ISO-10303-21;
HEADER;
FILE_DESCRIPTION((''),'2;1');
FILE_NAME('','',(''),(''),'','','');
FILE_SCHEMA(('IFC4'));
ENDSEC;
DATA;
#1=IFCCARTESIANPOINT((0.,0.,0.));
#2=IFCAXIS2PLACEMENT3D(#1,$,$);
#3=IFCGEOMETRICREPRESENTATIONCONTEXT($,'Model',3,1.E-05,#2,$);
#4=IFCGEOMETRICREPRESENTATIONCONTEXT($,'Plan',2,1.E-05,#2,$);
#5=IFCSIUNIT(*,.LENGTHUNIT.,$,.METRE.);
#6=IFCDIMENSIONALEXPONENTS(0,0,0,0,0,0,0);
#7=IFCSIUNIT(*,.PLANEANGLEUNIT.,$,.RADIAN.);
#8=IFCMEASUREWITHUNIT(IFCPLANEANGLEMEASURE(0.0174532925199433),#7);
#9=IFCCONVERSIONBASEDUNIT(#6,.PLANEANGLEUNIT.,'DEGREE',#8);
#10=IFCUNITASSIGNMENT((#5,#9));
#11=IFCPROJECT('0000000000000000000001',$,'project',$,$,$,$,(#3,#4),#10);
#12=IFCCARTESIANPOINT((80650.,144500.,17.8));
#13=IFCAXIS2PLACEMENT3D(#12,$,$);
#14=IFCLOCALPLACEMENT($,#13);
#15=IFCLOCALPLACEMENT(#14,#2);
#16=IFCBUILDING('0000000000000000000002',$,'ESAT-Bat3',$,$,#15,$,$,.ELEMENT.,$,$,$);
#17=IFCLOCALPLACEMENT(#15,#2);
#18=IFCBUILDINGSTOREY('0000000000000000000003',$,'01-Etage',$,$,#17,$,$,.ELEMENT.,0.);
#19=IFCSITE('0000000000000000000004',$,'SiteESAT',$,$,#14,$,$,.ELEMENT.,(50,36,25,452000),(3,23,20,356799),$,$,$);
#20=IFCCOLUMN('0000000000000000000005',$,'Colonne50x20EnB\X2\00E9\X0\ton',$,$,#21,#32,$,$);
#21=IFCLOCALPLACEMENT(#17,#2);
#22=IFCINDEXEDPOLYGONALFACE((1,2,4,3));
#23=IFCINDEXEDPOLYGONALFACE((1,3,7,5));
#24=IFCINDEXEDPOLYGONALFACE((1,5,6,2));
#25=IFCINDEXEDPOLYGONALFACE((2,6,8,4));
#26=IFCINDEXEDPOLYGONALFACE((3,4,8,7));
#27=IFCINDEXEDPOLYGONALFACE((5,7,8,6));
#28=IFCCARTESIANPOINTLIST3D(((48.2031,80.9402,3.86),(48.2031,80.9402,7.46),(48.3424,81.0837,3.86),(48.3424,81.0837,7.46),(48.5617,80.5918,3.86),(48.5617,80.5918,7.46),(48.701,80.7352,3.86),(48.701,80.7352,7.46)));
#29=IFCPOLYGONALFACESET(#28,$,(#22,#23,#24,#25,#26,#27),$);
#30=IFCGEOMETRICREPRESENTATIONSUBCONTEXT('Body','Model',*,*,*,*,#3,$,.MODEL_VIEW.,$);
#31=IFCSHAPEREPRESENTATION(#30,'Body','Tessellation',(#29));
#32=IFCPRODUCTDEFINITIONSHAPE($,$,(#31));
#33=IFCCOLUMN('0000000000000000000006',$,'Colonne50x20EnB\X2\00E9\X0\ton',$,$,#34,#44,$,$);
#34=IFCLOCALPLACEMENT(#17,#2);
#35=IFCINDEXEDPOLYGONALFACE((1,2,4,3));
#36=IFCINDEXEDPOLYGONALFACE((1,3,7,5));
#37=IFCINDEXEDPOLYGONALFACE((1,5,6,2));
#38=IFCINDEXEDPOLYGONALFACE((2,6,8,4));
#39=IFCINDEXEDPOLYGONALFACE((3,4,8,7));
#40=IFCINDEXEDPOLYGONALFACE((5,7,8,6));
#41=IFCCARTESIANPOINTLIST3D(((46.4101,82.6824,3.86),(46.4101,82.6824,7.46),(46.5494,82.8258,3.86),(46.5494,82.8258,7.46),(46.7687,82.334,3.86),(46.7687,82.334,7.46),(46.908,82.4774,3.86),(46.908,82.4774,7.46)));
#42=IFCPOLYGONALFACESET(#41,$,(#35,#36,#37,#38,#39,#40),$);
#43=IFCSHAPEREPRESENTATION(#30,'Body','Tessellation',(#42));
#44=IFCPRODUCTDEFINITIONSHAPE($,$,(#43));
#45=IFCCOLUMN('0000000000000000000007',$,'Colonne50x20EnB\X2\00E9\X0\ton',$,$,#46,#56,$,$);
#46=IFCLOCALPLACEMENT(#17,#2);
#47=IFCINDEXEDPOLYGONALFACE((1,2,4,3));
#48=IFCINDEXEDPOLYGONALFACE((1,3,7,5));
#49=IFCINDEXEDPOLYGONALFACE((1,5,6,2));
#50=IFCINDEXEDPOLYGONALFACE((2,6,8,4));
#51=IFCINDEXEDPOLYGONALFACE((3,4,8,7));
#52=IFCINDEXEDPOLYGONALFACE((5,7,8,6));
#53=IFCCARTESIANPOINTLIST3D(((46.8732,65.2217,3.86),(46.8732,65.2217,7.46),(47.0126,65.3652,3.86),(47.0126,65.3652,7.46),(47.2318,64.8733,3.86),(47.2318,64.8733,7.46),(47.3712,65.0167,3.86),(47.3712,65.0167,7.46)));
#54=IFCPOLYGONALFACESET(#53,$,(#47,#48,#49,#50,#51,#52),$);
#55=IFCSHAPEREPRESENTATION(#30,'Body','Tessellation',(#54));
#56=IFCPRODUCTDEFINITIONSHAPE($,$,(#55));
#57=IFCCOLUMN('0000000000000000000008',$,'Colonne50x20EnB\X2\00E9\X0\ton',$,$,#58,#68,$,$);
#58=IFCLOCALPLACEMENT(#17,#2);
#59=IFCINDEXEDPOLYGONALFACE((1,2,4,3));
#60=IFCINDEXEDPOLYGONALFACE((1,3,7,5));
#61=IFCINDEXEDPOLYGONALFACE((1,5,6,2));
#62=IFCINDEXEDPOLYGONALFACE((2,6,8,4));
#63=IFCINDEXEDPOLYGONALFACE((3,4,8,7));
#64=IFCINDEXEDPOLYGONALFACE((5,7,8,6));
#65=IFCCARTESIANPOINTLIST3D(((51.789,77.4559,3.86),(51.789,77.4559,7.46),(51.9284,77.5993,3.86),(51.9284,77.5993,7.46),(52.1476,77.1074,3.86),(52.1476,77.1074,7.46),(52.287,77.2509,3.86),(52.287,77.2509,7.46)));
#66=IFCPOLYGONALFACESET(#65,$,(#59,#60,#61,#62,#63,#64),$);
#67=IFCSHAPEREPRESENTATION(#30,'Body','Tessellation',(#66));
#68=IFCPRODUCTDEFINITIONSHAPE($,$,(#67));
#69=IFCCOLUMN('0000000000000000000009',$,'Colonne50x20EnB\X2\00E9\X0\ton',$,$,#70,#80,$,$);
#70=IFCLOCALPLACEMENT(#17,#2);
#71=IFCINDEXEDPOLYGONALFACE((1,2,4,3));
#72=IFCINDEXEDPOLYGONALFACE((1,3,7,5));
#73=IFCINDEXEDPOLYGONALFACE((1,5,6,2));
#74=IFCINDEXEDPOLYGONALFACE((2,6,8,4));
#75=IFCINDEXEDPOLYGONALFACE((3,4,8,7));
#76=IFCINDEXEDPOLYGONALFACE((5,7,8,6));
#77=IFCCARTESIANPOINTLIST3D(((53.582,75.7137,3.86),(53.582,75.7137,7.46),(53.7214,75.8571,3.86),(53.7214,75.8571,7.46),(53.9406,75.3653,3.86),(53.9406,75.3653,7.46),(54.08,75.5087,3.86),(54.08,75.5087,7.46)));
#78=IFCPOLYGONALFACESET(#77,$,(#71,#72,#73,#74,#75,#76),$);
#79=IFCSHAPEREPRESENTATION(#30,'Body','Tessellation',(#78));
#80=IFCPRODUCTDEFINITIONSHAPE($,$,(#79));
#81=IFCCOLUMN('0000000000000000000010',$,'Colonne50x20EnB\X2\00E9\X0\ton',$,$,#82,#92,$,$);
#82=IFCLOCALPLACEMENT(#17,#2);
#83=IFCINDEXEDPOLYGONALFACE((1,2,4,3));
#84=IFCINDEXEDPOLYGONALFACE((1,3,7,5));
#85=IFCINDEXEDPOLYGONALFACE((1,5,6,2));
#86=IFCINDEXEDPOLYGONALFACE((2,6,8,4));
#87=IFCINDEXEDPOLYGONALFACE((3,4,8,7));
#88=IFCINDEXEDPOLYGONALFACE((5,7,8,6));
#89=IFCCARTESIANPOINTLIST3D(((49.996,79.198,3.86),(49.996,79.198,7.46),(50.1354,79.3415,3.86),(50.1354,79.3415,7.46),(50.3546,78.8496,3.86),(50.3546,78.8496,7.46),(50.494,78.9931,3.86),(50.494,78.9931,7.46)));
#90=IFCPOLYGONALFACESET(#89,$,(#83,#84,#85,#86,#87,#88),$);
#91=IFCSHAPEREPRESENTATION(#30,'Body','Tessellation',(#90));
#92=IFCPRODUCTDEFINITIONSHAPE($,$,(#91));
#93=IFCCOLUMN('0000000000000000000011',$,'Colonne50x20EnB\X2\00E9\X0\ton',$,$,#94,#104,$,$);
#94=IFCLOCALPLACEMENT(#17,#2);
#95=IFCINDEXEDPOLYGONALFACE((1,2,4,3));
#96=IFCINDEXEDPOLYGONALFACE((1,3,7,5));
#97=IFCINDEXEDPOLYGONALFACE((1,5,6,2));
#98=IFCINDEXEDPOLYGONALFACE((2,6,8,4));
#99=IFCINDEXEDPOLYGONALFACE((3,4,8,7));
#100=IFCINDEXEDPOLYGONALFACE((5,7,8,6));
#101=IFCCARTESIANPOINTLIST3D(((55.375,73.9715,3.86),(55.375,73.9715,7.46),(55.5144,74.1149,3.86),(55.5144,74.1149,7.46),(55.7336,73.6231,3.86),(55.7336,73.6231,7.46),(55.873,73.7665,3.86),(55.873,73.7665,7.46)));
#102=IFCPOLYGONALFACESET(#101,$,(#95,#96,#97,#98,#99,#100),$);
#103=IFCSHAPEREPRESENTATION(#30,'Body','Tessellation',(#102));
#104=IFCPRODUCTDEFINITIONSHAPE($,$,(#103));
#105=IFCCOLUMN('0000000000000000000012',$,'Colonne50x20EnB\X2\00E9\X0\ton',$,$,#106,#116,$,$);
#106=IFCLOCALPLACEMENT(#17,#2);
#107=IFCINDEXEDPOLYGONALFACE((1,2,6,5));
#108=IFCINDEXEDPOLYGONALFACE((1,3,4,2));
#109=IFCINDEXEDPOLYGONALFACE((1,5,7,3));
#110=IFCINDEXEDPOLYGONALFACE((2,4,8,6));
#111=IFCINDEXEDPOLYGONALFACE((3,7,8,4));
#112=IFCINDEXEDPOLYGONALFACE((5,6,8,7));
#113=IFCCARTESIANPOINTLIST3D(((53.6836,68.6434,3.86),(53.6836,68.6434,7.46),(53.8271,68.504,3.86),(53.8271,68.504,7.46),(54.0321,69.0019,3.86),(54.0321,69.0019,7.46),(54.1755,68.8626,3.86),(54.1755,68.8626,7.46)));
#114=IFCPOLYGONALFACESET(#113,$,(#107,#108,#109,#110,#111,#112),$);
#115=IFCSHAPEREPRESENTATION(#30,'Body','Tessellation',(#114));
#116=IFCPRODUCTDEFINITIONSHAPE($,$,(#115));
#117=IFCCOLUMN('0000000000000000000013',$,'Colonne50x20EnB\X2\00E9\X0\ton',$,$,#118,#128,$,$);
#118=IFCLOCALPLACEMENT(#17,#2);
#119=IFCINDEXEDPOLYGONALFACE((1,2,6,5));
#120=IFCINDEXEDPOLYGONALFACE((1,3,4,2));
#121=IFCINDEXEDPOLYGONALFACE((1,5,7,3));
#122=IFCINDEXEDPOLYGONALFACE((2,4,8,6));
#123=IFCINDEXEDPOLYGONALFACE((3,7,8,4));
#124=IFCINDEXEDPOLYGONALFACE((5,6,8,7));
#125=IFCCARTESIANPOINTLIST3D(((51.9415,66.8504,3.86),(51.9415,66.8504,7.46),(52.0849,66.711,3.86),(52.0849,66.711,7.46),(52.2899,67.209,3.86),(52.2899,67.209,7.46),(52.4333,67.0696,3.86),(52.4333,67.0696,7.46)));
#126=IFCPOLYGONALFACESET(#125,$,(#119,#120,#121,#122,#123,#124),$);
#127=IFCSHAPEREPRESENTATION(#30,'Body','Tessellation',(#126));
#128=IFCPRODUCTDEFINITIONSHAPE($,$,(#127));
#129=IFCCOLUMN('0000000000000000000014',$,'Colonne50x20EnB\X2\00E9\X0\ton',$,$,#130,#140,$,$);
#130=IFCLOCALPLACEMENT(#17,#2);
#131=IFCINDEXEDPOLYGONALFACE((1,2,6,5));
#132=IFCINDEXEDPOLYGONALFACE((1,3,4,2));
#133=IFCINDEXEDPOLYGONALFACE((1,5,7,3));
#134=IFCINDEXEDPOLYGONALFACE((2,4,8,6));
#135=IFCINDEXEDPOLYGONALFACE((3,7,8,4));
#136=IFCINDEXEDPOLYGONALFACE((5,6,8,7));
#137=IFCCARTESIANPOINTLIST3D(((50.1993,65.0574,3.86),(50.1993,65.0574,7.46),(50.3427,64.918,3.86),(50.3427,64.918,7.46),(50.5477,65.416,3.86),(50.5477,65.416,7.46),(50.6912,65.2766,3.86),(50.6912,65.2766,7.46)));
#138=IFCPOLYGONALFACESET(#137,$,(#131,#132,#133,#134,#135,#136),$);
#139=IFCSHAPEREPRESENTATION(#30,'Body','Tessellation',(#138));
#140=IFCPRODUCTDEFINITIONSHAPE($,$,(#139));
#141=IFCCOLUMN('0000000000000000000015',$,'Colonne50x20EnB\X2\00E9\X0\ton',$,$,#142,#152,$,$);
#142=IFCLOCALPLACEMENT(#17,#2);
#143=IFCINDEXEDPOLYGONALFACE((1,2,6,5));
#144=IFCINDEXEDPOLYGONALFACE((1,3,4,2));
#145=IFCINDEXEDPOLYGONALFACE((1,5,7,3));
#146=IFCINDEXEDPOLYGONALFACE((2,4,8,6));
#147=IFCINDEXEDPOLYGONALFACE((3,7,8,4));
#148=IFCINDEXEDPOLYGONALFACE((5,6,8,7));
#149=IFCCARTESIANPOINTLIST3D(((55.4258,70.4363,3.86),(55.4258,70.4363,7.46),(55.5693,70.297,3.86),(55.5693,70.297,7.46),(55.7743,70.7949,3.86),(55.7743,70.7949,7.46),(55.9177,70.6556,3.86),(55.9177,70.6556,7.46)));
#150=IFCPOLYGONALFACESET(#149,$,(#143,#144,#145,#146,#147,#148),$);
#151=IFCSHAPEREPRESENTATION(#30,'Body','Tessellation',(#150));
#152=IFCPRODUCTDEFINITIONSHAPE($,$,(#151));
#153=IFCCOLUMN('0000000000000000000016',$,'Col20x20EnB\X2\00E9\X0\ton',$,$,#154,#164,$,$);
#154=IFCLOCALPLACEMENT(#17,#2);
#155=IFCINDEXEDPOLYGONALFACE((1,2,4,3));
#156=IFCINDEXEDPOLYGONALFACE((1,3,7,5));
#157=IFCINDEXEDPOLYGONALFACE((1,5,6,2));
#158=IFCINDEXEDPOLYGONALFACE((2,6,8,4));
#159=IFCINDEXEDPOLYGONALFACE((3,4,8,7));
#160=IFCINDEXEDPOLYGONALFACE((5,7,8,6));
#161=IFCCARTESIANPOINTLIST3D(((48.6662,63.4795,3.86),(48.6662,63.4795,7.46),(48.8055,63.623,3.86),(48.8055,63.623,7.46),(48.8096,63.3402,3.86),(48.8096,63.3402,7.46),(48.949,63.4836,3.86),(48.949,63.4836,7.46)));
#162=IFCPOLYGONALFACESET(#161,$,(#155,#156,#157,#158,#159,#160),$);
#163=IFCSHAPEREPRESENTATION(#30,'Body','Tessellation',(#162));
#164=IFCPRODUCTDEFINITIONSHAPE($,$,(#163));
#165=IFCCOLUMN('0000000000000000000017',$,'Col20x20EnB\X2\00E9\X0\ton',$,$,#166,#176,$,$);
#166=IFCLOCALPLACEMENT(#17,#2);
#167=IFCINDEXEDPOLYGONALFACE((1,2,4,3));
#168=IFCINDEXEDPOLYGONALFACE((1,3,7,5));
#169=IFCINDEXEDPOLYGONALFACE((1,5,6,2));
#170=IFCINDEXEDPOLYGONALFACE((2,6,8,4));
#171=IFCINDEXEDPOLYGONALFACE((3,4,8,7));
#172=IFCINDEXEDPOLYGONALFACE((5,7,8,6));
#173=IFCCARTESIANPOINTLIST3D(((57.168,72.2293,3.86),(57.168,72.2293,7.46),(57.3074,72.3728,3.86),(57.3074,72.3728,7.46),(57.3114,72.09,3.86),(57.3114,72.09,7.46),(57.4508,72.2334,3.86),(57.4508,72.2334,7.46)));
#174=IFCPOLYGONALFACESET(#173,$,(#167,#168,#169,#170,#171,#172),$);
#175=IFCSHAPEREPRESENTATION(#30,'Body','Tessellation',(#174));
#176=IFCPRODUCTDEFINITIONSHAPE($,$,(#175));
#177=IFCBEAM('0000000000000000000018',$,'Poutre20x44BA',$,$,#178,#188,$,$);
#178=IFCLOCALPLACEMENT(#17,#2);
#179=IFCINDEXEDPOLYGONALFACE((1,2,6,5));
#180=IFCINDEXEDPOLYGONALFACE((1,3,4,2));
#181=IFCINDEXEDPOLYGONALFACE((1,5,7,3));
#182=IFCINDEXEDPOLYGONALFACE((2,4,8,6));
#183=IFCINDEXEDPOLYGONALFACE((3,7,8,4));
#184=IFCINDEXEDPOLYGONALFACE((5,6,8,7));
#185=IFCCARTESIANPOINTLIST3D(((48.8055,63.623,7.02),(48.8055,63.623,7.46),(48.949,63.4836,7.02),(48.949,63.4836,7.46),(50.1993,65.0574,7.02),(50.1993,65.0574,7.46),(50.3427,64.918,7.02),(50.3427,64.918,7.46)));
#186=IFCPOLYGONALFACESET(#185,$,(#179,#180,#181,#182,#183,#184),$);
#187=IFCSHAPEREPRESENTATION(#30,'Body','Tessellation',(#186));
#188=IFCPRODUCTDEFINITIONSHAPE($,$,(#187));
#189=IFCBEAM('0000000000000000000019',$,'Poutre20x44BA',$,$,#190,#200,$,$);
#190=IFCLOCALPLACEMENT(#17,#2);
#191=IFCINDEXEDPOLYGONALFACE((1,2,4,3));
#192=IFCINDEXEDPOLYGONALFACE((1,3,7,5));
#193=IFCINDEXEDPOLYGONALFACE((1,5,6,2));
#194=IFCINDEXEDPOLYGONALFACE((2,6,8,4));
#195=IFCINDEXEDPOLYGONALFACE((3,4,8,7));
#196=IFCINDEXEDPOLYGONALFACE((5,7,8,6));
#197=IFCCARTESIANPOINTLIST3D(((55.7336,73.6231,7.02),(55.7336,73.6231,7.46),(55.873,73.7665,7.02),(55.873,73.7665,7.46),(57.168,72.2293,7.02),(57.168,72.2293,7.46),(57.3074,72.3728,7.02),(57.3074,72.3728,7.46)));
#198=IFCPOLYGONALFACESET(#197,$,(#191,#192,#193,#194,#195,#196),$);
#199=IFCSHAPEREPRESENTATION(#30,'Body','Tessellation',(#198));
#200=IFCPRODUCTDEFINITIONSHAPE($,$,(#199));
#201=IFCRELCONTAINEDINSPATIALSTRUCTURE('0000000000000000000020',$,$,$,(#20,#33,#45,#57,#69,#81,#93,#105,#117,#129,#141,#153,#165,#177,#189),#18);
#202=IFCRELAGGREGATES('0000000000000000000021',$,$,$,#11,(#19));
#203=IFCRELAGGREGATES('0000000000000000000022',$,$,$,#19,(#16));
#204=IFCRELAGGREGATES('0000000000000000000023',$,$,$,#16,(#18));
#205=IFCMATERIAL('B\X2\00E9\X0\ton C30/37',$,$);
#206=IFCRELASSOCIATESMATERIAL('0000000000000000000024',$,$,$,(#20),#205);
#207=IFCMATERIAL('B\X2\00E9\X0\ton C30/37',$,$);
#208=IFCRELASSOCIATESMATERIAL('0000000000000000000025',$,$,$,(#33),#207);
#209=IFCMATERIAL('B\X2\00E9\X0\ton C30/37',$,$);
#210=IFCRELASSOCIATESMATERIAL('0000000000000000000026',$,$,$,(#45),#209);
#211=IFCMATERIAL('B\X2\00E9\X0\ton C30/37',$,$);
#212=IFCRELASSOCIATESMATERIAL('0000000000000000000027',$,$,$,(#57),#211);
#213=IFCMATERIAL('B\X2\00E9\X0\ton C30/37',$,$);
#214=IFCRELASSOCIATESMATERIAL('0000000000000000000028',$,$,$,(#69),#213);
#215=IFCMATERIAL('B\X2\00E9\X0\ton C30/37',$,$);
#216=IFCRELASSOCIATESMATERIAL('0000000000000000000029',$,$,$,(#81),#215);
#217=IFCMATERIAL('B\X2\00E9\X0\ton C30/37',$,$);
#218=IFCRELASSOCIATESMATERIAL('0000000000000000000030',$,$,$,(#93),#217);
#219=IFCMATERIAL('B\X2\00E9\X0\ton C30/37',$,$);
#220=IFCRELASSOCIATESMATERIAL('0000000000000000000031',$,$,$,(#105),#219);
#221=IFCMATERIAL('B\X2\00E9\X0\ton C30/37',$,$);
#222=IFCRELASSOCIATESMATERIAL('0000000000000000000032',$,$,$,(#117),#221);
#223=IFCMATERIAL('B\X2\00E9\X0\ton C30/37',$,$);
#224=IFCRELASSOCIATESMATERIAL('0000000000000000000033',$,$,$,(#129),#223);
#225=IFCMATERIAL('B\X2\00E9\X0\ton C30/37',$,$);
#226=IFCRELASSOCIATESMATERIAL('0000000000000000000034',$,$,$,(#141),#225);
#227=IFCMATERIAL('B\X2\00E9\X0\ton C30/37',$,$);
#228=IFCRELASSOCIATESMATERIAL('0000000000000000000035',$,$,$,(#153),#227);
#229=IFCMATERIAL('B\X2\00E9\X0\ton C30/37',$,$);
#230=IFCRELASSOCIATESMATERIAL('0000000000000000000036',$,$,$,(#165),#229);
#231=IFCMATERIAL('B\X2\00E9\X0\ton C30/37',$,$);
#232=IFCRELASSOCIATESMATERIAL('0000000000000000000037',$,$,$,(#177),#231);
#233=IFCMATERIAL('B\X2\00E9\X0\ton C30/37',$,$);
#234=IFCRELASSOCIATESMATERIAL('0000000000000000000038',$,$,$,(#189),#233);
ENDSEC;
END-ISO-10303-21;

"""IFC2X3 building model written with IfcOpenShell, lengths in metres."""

from ifc_helpers import new_model, entity, si_unit, converted_unit, frame, frame_2d, origin, origin_with_axes, place, context, subcontext, project, spatial, rectangle, extrude, material, element, save


model = new_model("IFC2X3")

# Units and contexts
model_context = context("Model", 3, precision=1e-05, world=origin())
plan_context = context("Plan", 2, precision=1e-05, world=origin())
body_context = subcontext(model_context, "Body", "Model", "MODEL_VIEW")
ifc_project = project(units=[si_unit("LENGTHUNIT", "METRE"), converted_unit("PLANEANGLEUNIT", "DEGREE", entity("IfcPlaneAngleMeasure", 0.0174532925199433), si_unit("PLANEANGLEUNIT", "RADIAN"), dimensions=[0, 0, 0, 0, 0, 0, 0])], contexts=[model_context, plan_context])

# Site, building, storey
site_placement = place(None, frame((80650.0, 144500.0, 17.8)))
site = spatial("IfcSite", under=ifc_project, at=site_placement, Name="SiteESAT", CompositionType="ELEMENT", RefLatitude=(50, 36, 25, 452000), RefLongitude=(3, 23, 20, 356799))
building_placement = place(site_placement, origin())
building = spatial("IfcBuilding", under=site, at=building_placement, Name="ESAT-Bat3", CompositionType="ELEMENT")
storey_placement = place(building_placement, origin())
storey = spatial("IfcBuildingStorey", under=building, at=storey_placement, Name="01-Etage", CompositionType="ELEMENT", Elevation=0.0)

# Columns
ifc_material_1 = material(Name="Béton C30/37")
column_1_placement = place(storey_placement, frame((48.701, 80.7352, 3.86)))
element("IfcColumn", 1, at=column_1_placement, inside=storey, material=ifc_material_1, Name="Colonne50x20EnBéton", context=body_context, shape_type="SweptSolid", body=[
    extrude(rectangle(XDim=0.5, YDim=0.2, at=frame_2d((-0.249, 0.1025), x_axis=(-0.717196, 0.696872))), origin_with_axes(), (0.0, 0.0, 1.0), 3.6),
])
ifc_material_2 = material(Name="Béton C30/37")
column_2_placement = place(storey_placement, frame((46.908, 82.4774, 3.86)))
element("IfcColumn", 2, at=column_2_placement, inside=storey, material=ifc_material_2, Name="Colonne50x20EnBéton", context=body_context, shape_type="SweptSolid", body=[
    extrude(rectangle(XDim=0.5, YDim=0.2, at=frame_2d((-0.249, 0.1025), x_axis=(-0.717196, 0.696872))), origin_with_axes(), (0.0, 0.0, 1.0), 3.6),
])
ifc_material_3 = material(Name="Béton C30/37")
column_3_placement = place(storey_placement, frame((47.3712, 65.0167, 3.86)))
element("IfcColumn", 3, at=column_3_placement, inside=storey, material=ifc_material_3, Name="Colonne50x20EnBéton", context=body_context, shape_type="SweptSolid", body=[
    extrude(rectangle(XDim=0.5, YDim=0.2, at=frame_2d((-0.249, 0.1025), x_axis=(-0.717196, 0.696872))), origin_with_axes(), (0.0, 0.0, 1.0), 3.6),
])
ifc_material_4 = material(Name="Béton C30/37")
column_4_placement = place(storey_placement, frame((52.287, 77.2509, 3.86)))
element("IfcColumn", 4, at=column_4_placement, inside=storey, material=ifc_material_4, Name="Colonne50x20EnBéton", context=body_context, shape_type="SweptSolid", body=[
    extrude(rectangle(XDim=0.5, YDim=0.2, at=frame_2d((-0.249, 0.1025), x_axis=(-0.717196, 0.696872))), origin_with_axes(), (0.0, 0.0, 1.0), 3.6),
])
ifc_material_5 = material(Name="Béton C30/37")
column_5_placement = place(storey_placement, frame((54.08, 75.5087, 3.86)))
element("IfcColumn", 5, at=column_5_placement, inside=storey, material=ifc_material_5, Name="Colonne50x20EnBéton", context=body_context, shape_type="SweptSolid", body=[
    extrude(rectangle(XDim=0.5, YDim=0.2, at=frame_2d((-0.249, 0.1025), x_axis=(-0.717196, 0.696872))), origin_with_axes(), (0.0, 0.0, 1.0), 3.6),
])
ifc_material_6 = material(Name="Béton C30/37")
column_6_placement = place(storey_placement, frame((50.494, 78.9931, 3.86)))
element("IfcColumn", 6, at=column_6_placement, inside=storey, material=ifc_material_6, Name="Colonne50x20EnBéton", context=body_context, shape_type="SweptSolid", body=[
    extrude(rectangle(XDim=0.5, YDim=0.2, at=frame_2d((-0.249, 0.1025), x_axis=(-0.717196, 0.696872))), origin_with_axes(), (0.0, 0.0, 1.0), 3.6),
])
ifc_material_7 = material(Name="Béton C30/37")
column_7_placement = place(storey_placement, frame((55.873, 73.7665, 3.86)))
element("IfcColumn", 7, at=column_7_placement, inside=storey, material=ifc_material_7, Name="Colonne50x20EnBéton", context=body_context, shape_type="SweptSolid", body=[
    extrude(rectangle(XDim=0.5, YDim=0.2, at=frame_2d((-0.249, 0.1025), x_axis=(-0.717196, 0.696872))), origin_with_axes(), (0.0, 0.0, 1.0), 3.6),
])
ifc_material_8 = material(Name="Béton C30/37")
column_8_placement = place(storey_placement, frame((53.8271, 68.504, 3.86)))
element("IfcColumn", 8, at=column_8_placement, inside=storey, material=ifc_material_8, Name="Colonne50x20EnBéton", context=body_context, shape_type="SweptSolid", body=[
    extrude(rectangle(XDim=0.5, YDim=0.2, at=frame_2d((0.1025, 0.249), x_axis=(0.696872, 0.717196))), origin_with_axes(), (0.0, 0.0, 1.0), 3.6),
])
ifc_material_9 = material(Name="Béton C30/37")
column_9_placement = place(storey_placement, frame((52.0849, 66.711, 3.86)))
element("IfcColumn", 9, at=column_9_placement, inside=storey, material=ifc_material_9, Name="Colonne50x20EnBéton", context=body_context, shape_type="SweptSolid", body=[
    extrude(rectangle(XDim=0.5, YDim=0.2, at=frame_2d((0.1025, 0.249), x_axis=(0.696872, 0.717196))), origin_with_axes(), (0.0, 0.0, 1.0), 3.6),
])
ifc_material_10 = material(Name="Béton C30/37")
column_10_placement = place(storey_placement, frame((50.3427, 64.918, 3.86)))
element("IfcColumn", 10, at=column_10_placement, inside=storey, material=ifc_material_10, Name="Colonne50x20EnBéton", context=body_context, shape_type="SweptSolid", body=[
    extrude(rectangle(XDim=0.5, YDim=0.2, at=frame_2d((0.1025, 0.249), x_axis=(0.696872, 0.717196))), origin_with_axes(), (0.0, 0.0, 1.0), 3.6),
])
ifc_material_11 = material(Name="Béton C30/37")
column_11_placement = place(storey_placement, frame((55.5693, 70.297, 3.86)))
element("IfcColumn", 11, at=column_11_placement, inside=storey, material=ifc_material_11, Name="Colonne50x20EnBéton", context=body_context, shape_type="SweptSolid", body=[
    extrude(rectangle(XDim=0.5, YDim=0.2, at=frame_2d((0.1025, 0.249), x_axis=(0.696872, 0.717196))), origin_with_axes(), (0.0, 0.0, 1.0), 3.6),
])
ifc_material_12 = material(Name="Béton C30/37")
column_12_placement = place(storey_placement, frame((48.8096, 63.3402, 3.86)))
element("IfcColumn", 12, at=column_12_placement, inside=storey, material=ifc_material_12, Name="Col20x20EnBéton", context=body_context, shape_type="SweptSolid", body=[
    extrude(rectangle(XDim=0.2, YDim=0.2, at=frame_2d((-0.002, 0.1414), x_axis=(0.696872, 0.717196))), origin_with_axes(), (0.0, 0.0, 1.0), 3.6),
])
ifc_material_13 = material(Name="Béton C30/37")
column_13_placement = place(storey_placement, frame((57.3114, 72.09, 3.86)))
element("IfcColumn", 13, at=column_13_placement, inside=storey, material=ifc_material_13, Name="Col20x20EnBéton", context=body_context, shape_type="SweptSolid", body=[
    extrude(rectangle(XDim=0.2, YDim=0.2, at=frame_2d((-0.002, 0.1414), x_axis=(0.696872, 0.717196))), origin_with_axes(), (0.0, 0.0, 1.0), 3.6),
])

# Beams
ifc_material_14 = material(Name="Béton C30/37")
beam_1_placement = place(storey_placement, frame((48.949, 63.4836, 7.02), z_axis=(0.0, 0.0, 1.0), x_axis=(0.696872, 0.717196, 0.0)))
element("IfcBeam", 14, at=beam_1_placement, inside=storey, material=ifc_material_14, Name="Poutre20x44BA", context=body_context, shape_type="SweptSolid", body=[
    extrude(rectangle(XDim=0.2, YDim=0.44, at=frame_2d((0.1, 0.22), x_axis=(1.0, 0.0))), frame((0.0, 0.0, 0.0), z_axis=(1.0, 0.0, 0.0), x_axis=(0.0, 1.0, 0.0)), (0.0, 0.0, 1.0), 2.0),
])
ifc_material_15 = material(Name="Béton C30/37")
beam_2_placement = place(storey_placement, frame((57.3074, 72.3728, 7.02), z_axis=(0.0, 0.0, 1.0), x_axis=(-0.717196, 0.696872, 0.0)))
element("IfcBeam", 15, at=beam_2_placement, inside=storey, material=ifc_material_15, Name="Poutre20x44BA", context=body_context, shape_type="SweptSolid", body=[
    extrude(rectangle(XDim=0.2, YDim=0.44, at=frame_2d((0.1, 0.22), x_axis=(1.0, 0.0))), frame((0.0, 0.0, 0.0), z_axis=(1.0, 0.0, 0.0), x_axis=(0.0, 1.0, 0.0)), (0.0, 0.0, 1.0), 2.0),
])

save(model, "model.ifc")
